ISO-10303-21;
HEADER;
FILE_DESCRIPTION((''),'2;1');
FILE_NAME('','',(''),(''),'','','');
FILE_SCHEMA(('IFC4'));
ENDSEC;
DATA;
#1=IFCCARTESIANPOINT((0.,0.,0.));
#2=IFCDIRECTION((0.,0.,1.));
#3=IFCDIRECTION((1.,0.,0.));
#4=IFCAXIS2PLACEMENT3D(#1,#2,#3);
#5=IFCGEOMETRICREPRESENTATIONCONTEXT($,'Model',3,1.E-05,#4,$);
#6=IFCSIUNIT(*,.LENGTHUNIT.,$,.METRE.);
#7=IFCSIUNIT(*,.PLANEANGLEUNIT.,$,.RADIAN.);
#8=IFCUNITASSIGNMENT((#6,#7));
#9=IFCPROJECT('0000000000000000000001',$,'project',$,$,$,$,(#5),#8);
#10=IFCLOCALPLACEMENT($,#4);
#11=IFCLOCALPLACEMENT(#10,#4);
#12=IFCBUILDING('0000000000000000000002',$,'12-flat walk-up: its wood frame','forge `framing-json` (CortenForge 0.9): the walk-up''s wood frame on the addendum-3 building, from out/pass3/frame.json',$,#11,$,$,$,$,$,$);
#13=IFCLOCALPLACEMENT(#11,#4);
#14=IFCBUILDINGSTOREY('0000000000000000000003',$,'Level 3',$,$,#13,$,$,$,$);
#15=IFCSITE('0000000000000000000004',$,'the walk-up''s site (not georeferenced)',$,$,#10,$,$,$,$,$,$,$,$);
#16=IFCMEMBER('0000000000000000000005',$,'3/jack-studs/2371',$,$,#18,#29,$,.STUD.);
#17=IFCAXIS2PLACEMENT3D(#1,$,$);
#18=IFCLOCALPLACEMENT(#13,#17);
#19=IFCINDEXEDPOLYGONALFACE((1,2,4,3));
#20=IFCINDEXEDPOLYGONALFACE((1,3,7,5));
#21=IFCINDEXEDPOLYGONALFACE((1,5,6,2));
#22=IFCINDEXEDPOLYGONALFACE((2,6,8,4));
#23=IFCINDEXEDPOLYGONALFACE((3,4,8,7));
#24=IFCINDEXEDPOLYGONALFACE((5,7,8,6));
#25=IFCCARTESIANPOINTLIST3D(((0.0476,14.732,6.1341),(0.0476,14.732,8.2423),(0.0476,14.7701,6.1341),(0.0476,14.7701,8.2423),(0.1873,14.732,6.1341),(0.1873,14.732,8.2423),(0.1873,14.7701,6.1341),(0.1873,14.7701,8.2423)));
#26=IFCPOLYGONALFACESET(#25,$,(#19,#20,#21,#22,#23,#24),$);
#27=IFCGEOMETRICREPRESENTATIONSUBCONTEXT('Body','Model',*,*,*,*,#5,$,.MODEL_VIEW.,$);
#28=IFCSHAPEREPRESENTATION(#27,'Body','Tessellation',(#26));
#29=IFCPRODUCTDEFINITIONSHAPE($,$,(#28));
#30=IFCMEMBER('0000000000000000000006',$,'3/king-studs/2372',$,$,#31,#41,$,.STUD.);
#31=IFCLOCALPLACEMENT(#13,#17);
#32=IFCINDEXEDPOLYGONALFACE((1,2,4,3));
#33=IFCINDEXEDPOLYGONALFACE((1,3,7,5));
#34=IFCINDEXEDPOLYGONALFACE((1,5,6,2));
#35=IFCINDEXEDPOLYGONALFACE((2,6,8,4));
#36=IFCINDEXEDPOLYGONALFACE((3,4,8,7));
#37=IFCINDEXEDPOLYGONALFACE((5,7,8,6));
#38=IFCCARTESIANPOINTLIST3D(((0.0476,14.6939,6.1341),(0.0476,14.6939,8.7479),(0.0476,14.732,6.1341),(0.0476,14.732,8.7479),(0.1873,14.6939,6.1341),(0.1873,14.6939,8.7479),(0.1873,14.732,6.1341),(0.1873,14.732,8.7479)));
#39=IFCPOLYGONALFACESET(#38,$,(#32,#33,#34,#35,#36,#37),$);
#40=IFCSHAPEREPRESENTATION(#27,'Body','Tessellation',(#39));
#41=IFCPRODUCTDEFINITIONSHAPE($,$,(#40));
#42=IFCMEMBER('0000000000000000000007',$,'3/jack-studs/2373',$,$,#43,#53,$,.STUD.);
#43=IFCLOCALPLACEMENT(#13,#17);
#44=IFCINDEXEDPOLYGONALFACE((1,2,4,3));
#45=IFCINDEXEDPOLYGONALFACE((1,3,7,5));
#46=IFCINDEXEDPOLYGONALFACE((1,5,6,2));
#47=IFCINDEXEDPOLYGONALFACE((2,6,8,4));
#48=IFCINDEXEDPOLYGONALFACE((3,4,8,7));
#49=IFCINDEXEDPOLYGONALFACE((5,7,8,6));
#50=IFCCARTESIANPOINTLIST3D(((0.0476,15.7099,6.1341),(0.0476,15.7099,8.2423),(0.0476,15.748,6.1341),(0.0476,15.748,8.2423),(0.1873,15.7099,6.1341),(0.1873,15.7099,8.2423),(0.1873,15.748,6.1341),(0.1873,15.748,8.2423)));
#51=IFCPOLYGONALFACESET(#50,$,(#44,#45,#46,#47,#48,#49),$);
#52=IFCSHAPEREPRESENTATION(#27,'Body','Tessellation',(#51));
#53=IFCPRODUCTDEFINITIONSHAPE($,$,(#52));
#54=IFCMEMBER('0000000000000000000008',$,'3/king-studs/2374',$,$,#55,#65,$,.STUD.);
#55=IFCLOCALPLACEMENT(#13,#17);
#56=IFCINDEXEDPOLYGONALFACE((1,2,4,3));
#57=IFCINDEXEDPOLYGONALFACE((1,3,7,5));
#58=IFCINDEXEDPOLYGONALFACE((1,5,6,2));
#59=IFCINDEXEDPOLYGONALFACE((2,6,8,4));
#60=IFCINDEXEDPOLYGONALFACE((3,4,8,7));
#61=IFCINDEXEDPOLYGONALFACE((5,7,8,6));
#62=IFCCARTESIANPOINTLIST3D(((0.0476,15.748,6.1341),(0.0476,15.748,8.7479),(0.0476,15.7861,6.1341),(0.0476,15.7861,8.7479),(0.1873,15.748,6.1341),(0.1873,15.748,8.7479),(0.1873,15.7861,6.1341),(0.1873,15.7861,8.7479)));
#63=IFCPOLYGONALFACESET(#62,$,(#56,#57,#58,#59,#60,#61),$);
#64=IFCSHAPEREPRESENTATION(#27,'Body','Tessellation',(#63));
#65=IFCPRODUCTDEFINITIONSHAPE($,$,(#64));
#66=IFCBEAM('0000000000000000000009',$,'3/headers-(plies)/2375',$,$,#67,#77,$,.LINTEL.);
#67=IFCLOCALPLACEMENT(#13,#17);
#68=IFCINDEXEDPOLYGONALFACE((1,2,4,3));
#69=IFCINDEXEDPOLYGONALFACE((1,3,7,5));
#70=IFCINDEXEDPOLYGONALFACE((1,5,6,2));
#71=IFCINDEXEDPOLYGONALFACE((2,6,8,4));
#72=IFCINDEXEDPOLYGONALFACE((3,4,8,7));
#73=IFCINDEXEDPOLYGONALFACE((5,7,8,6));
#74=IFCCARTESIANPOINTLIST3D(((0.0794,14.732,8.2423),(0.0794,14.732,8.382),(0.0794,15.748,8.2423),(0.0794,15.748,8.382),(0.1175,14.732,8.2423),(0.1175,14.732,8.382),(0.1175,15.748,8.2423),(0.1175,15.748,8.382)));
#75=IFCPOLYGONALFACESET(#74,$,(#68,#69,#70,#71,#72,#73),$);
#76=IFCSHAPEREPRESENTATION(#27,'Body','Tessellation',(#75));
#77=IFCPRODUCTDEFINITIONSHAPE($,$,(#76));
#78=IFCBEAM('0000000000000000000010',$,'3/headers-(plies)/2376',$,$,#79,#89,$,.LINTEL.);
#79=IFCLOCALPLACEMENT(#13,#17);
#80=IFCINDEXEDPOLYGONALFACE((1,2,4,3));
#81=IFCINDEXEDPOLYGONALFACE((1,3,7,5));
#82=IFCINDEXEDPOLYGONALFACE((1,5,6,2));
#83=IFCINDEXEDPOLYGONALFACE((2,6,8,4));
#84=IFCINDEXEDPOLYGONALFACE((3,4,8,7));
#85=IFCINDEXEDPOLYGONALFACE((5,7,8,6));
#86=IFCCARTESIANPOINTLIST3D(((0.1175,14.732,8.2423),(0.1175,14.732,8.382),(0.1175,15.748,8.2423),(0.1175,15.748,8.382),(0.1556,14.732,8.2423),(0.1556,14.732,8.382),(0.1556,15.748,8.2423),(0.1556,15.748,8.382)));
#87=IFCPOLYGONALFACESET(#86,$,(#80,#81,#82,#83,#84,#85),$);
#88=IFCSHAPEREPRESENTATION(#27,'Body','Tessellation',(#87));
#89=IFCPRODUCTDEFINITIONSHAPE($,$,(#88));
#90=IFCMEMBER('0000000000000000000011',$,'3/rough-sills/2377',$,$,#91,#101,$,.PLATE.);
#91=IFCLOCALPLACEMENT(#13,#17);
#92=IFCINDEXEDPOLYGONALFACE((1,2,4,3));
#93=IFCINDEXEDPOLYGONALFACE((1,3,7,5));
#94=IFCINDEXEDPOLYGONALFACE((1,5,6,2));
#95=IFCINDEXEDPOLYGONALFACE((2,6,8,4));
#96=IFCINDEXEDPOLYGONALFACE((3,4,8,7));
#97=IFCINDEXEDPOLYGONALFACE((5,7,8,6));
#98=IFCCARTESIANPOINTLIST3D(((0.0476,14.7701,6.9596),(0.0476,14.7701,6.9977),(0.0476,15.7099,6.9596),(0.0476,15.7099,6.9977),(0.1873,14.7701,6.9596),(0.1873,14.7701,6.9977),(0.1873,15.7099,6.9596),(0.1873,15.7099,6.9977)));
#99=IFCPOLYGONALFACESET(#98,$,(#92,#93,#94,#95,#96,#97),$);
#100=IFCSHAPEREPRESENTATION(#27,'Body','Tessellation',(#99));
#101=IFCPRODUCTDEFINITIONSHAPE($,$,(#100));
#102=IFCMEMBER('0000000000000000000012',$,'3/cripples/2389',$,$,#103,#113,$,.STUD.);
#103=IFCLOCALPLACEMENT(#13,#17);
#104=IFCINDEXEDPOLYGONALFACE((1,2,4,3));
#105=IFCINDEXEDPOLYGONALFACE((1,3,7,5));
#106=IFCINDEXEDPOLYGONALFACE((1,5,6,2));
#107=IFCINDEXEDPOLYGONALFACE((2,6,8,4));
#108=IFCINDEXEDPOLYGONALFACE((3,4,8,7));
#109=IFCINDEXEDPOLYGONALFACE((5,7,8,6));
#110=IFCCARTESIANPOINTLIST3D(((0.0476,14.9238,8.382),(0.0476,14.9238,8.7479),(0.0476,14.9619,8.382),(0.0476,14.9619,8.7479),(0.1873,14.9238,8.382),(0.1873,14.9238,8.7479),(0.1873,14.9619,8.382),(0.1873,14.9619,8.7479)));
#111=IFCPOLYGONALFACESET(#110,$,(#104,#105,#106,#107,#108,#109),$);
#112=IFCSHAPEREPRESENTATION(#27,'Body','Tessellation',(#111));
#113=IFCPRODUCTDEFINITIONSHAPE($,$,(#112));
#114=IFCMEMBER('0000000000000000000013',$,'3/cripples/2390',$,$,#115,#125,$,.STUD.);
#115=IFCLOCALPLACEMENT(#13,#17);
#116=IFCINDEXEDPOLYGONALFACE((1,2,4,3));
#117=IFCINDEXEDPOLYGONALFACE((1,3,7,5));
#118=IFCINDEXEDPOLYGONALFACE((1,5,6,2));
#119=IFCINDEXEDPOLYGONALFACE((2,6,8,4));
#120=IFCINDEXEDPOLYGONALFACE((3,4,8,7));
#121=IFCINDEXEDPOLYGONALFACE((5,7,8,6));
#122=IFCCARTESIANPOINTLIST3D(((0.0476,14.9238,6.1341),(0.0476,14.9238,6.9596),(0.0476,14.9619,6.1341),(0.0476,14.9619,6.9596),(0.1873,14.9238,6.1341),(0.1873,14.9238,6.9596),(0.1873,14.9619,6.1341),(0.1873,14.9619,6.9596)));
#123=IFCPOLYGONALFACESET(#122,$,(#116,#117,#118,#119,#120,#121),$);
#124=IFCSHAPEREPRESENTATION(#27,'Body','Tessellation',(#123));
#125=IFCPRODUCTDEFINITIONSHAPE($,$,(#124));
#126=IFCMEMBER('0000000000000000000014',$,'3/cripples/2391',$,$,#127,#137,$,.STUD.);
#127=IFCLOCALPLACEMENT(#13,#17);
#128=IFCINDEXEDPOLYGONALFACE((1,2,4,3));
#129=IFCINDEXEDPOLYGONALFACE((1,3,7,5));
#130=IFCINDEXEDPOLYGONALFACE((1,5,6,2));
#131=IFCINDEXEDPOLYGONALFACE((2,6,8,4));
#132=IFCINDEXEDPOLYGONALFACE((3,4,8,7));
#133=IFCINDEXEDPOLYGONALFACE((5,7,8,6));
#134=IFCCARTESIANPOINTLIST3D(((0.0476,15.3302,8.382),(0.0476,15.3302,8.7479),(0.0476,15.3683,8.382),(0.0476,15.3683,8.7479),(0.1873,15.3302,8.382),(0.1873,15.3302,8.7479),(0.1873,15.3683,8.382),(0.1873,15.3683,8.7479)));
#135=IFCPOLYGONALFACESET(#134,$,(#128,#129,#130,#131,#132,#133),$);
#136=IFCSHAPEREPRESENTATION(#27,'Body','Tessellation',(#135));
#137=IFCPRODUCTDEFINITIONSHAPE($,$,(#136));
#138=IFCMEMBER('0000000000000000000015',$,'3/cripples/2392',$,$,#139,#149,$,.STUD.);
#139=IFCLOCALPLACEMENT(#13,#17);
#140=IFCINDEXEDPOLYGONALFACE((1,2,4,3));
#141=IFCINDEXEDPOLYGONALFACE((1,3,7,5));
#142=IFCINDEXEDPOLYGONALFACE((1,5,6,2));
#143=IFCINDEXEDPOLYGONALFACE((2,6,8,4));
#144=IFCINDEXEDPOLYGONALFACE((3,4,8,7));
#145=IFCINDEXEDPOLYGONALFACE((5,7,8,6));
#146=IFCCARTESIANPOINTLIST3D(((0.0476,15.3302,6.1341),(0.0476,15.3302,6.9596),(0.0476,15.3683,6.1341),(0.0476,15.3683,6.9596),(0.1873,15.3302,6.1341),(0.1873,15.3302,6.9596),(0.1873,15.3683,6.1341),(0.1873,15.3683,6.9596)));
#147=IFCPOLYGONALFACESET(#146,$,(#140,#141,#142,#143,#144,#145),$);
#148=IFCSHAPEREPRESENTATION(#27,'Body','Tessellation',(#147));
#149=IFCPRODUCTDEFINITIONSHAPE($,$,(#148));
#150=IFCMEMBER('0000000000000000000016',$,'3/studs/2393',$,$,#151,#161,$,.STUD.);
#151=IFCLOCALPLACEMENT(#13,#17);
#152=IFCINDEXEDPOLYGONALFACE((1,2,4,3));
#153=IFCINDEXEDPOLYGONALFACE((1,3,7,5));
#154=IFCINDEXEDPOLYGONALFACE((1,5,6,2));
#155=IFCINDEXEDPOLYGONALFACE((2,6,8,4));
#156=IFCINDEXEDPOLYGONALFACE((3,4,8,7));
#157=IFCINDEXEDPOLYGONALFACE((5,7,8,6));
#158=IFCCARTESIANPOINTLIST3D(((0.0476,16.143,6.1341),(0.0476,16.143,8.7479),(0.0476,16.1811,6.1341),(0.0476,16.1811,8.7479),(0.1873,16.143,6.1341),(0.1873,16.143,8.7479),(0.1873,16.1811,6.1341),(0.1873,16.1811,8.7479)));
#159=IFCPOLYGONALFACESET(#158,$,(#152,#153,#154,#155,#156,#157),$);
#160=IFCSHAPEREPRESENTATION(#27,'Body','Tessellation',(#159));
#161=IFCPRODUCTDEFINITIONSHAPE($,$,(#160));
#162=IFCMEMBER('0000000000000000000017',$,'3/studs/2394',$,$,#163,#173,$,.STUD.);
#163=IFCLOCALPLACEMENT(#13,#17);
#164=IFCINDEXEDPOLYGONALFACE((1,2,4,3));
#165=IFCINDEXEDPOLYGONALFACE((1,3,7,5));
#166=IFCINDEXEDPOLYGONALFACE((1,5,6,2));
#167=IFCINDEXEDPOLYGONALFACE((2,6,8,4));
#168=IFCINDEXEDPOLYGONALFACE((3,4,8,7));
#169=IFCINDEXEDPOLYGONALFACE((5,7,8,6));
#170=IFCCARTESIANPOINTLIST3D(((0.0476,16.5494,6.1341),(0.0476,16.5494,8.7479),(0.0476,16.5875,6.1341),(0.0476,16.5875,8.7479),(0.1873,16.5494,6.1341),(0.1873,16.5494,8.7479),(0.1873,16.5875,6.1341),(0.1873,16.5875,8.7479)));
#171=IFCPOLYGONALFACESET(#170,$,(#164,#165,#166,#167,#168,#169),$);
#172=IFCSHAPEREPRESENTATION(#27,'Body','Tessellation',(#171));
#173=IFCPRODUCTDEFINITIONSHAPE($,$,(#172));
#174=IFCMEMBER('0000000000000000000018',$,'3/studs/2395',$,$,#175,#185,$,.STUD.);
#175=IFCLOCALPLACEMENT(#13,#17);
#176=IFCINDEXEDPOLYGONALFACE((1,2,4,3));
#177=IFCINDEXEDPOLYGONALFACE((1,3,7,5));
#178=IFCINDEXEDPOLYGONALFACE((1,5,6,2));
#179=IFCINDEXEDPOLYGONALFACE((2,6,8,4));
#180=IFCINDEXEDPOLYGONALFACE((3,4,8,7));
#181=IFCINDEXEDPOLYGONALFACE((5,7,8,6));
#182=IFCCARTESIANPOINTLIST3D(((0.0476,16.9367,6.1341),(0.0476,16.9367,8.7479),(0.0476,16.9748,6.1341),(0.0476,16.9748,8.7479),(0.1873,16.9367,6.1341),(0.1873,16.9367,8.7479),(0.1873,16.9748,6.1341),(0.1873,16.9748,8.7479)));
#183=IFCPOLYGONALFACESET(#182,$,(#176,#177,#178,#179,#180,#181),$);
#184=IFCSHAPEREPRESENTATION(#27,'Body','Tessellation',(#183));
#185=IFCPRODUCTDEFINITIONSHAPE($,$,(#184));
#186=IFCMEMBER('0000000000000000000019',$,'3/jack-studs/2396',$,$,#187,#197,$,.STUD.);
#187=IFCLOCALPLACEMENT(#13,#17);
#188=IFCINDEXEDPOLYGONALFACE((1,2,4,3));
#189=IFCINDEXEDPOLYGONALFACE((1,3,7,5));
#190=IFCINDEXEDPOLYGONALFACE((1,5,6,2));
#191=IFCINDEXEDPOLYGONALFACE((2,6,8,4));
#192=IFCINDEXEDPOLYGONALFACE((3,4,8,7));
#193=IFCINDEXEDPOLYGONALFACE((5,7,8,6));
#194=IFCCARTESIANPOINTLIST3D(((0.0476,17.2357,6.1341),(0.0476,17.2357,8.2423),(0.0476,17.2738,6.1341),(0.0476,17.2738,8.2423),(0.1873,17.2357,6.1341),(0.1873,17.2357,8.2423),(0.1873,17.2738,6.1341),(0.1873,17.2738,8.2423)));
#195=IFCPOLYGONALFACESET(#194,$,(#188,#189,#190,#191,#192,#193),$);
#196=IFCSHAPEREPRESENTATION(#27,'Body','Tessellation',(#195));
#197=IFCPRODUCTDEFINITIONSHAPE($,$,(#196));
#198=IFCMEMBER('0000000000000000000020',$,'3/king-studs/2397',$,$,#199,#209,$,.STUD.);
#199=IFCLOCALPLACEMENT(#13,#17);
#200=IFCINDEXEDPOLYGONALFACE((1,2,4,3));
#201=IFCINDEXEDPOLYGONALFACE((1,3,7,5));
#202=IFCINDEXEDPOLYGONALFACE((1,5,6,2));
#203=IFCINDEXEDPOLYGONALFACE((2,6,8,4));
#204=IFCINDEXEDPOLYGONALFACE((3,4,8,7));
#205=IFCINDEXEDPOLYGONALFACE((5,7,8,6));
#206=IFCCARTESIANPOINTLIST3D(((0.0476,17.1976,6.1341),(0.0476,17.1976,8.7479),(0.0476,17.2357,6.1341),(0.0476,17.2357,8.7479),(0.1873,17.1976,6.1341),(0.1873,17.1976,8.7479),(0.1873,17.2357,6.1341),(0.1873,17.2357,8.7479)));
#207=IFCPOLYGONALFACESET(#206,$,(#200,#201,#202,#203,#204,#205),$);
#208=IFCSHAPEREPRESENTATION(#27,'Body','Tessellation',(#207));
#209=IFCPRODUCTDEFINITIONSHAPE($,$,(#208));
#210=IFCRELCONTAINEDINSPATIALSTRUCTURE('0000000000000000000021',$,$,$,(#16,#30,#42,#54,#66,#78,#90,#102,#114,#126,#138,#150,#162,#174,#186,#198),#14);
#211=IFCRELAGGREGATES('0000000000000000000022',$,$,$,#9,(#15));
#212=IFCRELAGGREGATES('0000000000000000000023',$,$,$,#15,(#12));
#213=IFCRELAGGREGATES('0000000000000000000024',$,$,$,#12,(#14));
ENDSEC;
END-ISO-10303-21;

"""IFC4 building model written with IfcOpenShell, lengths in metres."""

from ifc_helpers import new_model, si_unit, frame, frame_2d, origin, origin_with_axes, place, context, subcontext, project, spatial, rectangle, extrude, element, save


model = new_model("IFC4")

# Units and contexts
model_context = context("Model", 3, precision=1e-05, world=origin_with_axes())
body_context = subcontext(model_context, "Body", "Model", "MODEL_VIEW")
ifc_project = project(units=[si_unit("LENGTHUNIT", "METRE"), si_unit("PLANEANGLEUNIT", "RADIAN")], contexts=[model_context])

# Site, building, storey
site_placement = place(None, origin_with_axes())
site = spatial("IfcSite", under=ifc_project, at=site_placement, Name="the walk-up's site (not georeferenced)")
building_placement = place(site_placement, origin_with_axes())
building = spatial("IfcBuilding", under=site, at=building_placement, Name="12-flat walk-up: its wood frame", Description="forge `framing-json` (CortenForge 0.9): the walk-up's wood frame on the addendum-3 building, from out/pass3/frame.json")
storey_placement = place(building_placement, origin_with_axes())
storey = spatial("IfcBuildingStorey", under=building, at=storey_placement, Name="Level 3")

# Members
member_1_placement = place(storey_placement, frame((0.0476, 14.732, 6.1341), z_axis=(0.0, 0.0, 1.0), x_axis=(1.0, 0.0, 0.0)))
element("IfcMember", 1, at=member_1_placement, inside=storey, Name="3/jack-studs/2371", PredefinedType="STUD", context=body_context, shape_type="SweptSolid", body=[
    extrude(rectangle(XDim=0.1397, YDim=0.0381, at=frame_2d((0.0698, 0.0191))), origin(), (0.0, 0.0, 1.0), 2.1082),
])
member_2_placement = place(storey_placement, frame((0.0476, 14.6939, 6.1341), z_axis=(0.0, 0.0, 1.0), x_axis=(1.0, 0.0, 0.0)))
element("IfcMember", 2, at=member_2_placement, inside=storey, Name="3/king-studs/2372", PredefinedType="STUD", context=body_context, shape_type="SweptSolid", body=[
    extrude(rectangle(XDim=0.1397, YDim=0.0381, at=frame_2d((0.0698, 0.0191))), origin(), (0.0, 0.0, 1.0), 2.6138),
])
member_3_placement = place(storey_placement, frame((0.0476, 15.7099, 6.1341), z_axis=(0.0, 0.0, 1.0), x_axis=(1.0, 0.0, 0.0)))
element("IfcMember", 3, at=member_3_placement, inside=storey, Name="3/jack-studs/2373", PredefinedType="STUD", context=body_context, shape_type="SweptSolid", body=[
    extrude(rectangle(XDim=0.1397, YDim=0.0381, at=frame_2d((0.0698, 0.0191))), origin(), (0.0, 0.0, 1.0), 2.1082),
])
member_4_placement = place(storey_placement, frame((0.0476, 15.748, 6.1341), z_axis=(0.0, 0.0, 1.0), x_axis=(1.0, 0.0, 0.0)))
element("IfcMember", 4, at=member_4_placement, inside=storey, Name="3/king-studs/2374", PredefinedType="STUD", context=body_context, shape_type="SweptSolid", body=[
    extrude(rectangle(XDim=0.1397, YDim=0.0381, at=frame_2d((0.0698, 0.0191))), origin(), (0.0, 0.0, 1.0), 2.6138),
])

# Beams
for number, where, z_axis, x_axis, name in (
    (5, (0.0794, 14.732, 8.2423), (0.0, 0.0, 1.0), (1.0, 0.0, 0.0), "3/headers-(plies)/2375"),
    (6, (0.1175, 14.732, 8.2423), (0.0, 0.0, 1.0), (1.0, 0.0, 0.0), "3/headers-(plies)/2376"),
):
    element("IfcBeam", number, at=place(storey_placement, frame(where, z_axis=z_axis, x_axis=x_axis)), inside=storey, Name=name, PredefinedType="LINTEL", context=body_context, shape_type="SweptSolid", body=[
        extrude(rectangle(XDim=0.0381, YDim=1.016, at=frame_2d((0.019, 0.508))), origin(), (0.0, 0.0, 1.0), 0.1397),
    ])

# Members
member_5_placement = place(storey_placement, frame((0.0476, 14.7701, 6.9596), z_axis=(0.0, 0.0, 1.0), x_axis=(1.0, 0.0, 0.0)))
element("IfcMember", 7, at=member_5_placement, inside=storey, Name="3/rough-sills/2377", PredefinedType="PLATE", context=body_context, shape_type="SweptSolid", body=[
    extrude(rectangle(XDim=0.1397, YDim=0.9398, at=frame_2d((0.0698, 0.4699))), origin(), (0.0, 0.0, 1.0), 0.0381),
])
member_6_placement = place(storey_placement, frame((0.0476, 14.9238, 8.382), z_axis=(0.0, 0.0, 1.0), x_axis=(1.0, 0.0, 0.0)))
element("IfcMember", 8, at=member_6_placement, inside=storey, Name="3/cripples/2389", PredefinedType="STUD", context=body_context, shape_type="SweptSolid", body=[
    extrude(rectangle(XDim=0.1397, YDim=0.0381, at=frame_2d((0.0698, 0.0191))), origin(), (0.0, 0.0, 1.0), 0.3659),
])
member_7_placement = place(storey_placement, frame((0.0476, 14.9238, 6.1341), z_axis=(0.0, 0.0, 1.0), x_axis=(1.0, 0.0, 0.0)))
element("IfcMember", 9, at=member_7_placement, inside=storey, Name="3/cripples/2390", PredefinedType="STUD", context=body_context, shape_type="SweptSolid", body=[
    extrude(rectangle(XDim=0.1397, YDim=0.0381, at=frame_2d((0.0698, 0.0191))), origin(), (0.0, 0.0, 1.0), 0.8255),
])
member_8_placement = place(storey_placement, frame((0.0476, 15.3302, 8.382), z_axis=(0.0, 0.0, 1.0), x_axis=(1.0, 0.0, 0.0)))
element("IfcMember", 10, at=member_8_placement, inside=storey, Name="3/cripples/2391", PredefinedType="STUD", context=body_context, shape_type="SweptSolid", body=[
    extrude(rectangle(XDim=0.1397, YDim=0.0381, at=frame_2d((0.0698, 0.0191))), origin(), (0.0, 0.0, 1.0), 0.3659),
])
member_9_placement = place(storey_placement, frame((0.0476, 15.3302, 6.1341), z_axis=(0.0, 0.0, 1.0), x_axis=(1.0, 0.0, 0.0)))
element("IfcMember", 11, at=member_9_placement, inside=storey, Name="3/cripples/2392", PredefinedType="STUD", context=body_context, shape_type="SweptSolid", body=[
    extrude(rectangle(XDim=0.1397, YDim=0.0381, at=frame_2d((0.0698, 0.0191))), origin(), (0.0, 0.0, 1.0), 0.8255),
])
for number, where, z_axis, x_axis, name in (
    (12, (0.0476, 16.143, 6.1341), (0.0, 0.0, 1.0), (1.0, 0.0, 0.0), "3/studs/2393"),
    (13, (0.0476, 16.5494, 6.1341), (0.0, 0.0, 1.0), (1.0, 0.0, 0.0), "3/studs/2394"),
    (14, (0.0476, 16.9367, 6.1341), (0.0, 0.0, 1.0), (1.0, 0.0, 0.0), "3/studs/2395"),
):
    element("IfcMember", number, at=place(storey_placement, frame(where, z_axis=z_axis, x_axis=x_axis)), inside=storey, Name=name, PredefinedType="STUD", context=body_context, shape_type="SweptSolid", body=[
        extrude(rectangle(XDim=0.1397, YDim=0.0381, at=frame_2d((0.0698, 0.0191))), origin(), (0.0, 0.0, 1.0), 2.6138),
    ])
member_10_placement = place(storey_placement, frame((0.0476, 17.2357, 6.1341), z_axis=(0.0, 0.0, 1.0), x_axis=(1.0, 0.0, 0.0)))
element("IfcMember", 15, at=member_10_placement, inside=storey, Name="3/jack-studs/2396", PredefinedType="STUD", context=body_context, shape_type="SweptSolid", body=[
    extrude(rectangle(XDim=0.1397, YDim=0.0381, at=frame_2d((0.0698, 0.0191))), origin(), (0.0, 0.0, 1.0), 2.1082),
])
member_11_placement = place(storey_placement, frame((0.0476, 17.1976, 6.1341), z_axis=(0.0, 0.0, 1.0), x_axis=(1.0, 0.0, 0.0)))
element("IfcMember", 16, at=member_11_placement, inside=storey, Name="3/king-studs/2397", PredefinedType="STUD", context=body_context, shape_type="SweptSolid", body=[
    extrude(rectangle(XDim=0.1397, YDim=0.0381, at=frame_2d((0.0698, 0.0191))), origin(), (0.0, 0.0, 1.0), 2.6138),
])

save(model, "model.ifc")
